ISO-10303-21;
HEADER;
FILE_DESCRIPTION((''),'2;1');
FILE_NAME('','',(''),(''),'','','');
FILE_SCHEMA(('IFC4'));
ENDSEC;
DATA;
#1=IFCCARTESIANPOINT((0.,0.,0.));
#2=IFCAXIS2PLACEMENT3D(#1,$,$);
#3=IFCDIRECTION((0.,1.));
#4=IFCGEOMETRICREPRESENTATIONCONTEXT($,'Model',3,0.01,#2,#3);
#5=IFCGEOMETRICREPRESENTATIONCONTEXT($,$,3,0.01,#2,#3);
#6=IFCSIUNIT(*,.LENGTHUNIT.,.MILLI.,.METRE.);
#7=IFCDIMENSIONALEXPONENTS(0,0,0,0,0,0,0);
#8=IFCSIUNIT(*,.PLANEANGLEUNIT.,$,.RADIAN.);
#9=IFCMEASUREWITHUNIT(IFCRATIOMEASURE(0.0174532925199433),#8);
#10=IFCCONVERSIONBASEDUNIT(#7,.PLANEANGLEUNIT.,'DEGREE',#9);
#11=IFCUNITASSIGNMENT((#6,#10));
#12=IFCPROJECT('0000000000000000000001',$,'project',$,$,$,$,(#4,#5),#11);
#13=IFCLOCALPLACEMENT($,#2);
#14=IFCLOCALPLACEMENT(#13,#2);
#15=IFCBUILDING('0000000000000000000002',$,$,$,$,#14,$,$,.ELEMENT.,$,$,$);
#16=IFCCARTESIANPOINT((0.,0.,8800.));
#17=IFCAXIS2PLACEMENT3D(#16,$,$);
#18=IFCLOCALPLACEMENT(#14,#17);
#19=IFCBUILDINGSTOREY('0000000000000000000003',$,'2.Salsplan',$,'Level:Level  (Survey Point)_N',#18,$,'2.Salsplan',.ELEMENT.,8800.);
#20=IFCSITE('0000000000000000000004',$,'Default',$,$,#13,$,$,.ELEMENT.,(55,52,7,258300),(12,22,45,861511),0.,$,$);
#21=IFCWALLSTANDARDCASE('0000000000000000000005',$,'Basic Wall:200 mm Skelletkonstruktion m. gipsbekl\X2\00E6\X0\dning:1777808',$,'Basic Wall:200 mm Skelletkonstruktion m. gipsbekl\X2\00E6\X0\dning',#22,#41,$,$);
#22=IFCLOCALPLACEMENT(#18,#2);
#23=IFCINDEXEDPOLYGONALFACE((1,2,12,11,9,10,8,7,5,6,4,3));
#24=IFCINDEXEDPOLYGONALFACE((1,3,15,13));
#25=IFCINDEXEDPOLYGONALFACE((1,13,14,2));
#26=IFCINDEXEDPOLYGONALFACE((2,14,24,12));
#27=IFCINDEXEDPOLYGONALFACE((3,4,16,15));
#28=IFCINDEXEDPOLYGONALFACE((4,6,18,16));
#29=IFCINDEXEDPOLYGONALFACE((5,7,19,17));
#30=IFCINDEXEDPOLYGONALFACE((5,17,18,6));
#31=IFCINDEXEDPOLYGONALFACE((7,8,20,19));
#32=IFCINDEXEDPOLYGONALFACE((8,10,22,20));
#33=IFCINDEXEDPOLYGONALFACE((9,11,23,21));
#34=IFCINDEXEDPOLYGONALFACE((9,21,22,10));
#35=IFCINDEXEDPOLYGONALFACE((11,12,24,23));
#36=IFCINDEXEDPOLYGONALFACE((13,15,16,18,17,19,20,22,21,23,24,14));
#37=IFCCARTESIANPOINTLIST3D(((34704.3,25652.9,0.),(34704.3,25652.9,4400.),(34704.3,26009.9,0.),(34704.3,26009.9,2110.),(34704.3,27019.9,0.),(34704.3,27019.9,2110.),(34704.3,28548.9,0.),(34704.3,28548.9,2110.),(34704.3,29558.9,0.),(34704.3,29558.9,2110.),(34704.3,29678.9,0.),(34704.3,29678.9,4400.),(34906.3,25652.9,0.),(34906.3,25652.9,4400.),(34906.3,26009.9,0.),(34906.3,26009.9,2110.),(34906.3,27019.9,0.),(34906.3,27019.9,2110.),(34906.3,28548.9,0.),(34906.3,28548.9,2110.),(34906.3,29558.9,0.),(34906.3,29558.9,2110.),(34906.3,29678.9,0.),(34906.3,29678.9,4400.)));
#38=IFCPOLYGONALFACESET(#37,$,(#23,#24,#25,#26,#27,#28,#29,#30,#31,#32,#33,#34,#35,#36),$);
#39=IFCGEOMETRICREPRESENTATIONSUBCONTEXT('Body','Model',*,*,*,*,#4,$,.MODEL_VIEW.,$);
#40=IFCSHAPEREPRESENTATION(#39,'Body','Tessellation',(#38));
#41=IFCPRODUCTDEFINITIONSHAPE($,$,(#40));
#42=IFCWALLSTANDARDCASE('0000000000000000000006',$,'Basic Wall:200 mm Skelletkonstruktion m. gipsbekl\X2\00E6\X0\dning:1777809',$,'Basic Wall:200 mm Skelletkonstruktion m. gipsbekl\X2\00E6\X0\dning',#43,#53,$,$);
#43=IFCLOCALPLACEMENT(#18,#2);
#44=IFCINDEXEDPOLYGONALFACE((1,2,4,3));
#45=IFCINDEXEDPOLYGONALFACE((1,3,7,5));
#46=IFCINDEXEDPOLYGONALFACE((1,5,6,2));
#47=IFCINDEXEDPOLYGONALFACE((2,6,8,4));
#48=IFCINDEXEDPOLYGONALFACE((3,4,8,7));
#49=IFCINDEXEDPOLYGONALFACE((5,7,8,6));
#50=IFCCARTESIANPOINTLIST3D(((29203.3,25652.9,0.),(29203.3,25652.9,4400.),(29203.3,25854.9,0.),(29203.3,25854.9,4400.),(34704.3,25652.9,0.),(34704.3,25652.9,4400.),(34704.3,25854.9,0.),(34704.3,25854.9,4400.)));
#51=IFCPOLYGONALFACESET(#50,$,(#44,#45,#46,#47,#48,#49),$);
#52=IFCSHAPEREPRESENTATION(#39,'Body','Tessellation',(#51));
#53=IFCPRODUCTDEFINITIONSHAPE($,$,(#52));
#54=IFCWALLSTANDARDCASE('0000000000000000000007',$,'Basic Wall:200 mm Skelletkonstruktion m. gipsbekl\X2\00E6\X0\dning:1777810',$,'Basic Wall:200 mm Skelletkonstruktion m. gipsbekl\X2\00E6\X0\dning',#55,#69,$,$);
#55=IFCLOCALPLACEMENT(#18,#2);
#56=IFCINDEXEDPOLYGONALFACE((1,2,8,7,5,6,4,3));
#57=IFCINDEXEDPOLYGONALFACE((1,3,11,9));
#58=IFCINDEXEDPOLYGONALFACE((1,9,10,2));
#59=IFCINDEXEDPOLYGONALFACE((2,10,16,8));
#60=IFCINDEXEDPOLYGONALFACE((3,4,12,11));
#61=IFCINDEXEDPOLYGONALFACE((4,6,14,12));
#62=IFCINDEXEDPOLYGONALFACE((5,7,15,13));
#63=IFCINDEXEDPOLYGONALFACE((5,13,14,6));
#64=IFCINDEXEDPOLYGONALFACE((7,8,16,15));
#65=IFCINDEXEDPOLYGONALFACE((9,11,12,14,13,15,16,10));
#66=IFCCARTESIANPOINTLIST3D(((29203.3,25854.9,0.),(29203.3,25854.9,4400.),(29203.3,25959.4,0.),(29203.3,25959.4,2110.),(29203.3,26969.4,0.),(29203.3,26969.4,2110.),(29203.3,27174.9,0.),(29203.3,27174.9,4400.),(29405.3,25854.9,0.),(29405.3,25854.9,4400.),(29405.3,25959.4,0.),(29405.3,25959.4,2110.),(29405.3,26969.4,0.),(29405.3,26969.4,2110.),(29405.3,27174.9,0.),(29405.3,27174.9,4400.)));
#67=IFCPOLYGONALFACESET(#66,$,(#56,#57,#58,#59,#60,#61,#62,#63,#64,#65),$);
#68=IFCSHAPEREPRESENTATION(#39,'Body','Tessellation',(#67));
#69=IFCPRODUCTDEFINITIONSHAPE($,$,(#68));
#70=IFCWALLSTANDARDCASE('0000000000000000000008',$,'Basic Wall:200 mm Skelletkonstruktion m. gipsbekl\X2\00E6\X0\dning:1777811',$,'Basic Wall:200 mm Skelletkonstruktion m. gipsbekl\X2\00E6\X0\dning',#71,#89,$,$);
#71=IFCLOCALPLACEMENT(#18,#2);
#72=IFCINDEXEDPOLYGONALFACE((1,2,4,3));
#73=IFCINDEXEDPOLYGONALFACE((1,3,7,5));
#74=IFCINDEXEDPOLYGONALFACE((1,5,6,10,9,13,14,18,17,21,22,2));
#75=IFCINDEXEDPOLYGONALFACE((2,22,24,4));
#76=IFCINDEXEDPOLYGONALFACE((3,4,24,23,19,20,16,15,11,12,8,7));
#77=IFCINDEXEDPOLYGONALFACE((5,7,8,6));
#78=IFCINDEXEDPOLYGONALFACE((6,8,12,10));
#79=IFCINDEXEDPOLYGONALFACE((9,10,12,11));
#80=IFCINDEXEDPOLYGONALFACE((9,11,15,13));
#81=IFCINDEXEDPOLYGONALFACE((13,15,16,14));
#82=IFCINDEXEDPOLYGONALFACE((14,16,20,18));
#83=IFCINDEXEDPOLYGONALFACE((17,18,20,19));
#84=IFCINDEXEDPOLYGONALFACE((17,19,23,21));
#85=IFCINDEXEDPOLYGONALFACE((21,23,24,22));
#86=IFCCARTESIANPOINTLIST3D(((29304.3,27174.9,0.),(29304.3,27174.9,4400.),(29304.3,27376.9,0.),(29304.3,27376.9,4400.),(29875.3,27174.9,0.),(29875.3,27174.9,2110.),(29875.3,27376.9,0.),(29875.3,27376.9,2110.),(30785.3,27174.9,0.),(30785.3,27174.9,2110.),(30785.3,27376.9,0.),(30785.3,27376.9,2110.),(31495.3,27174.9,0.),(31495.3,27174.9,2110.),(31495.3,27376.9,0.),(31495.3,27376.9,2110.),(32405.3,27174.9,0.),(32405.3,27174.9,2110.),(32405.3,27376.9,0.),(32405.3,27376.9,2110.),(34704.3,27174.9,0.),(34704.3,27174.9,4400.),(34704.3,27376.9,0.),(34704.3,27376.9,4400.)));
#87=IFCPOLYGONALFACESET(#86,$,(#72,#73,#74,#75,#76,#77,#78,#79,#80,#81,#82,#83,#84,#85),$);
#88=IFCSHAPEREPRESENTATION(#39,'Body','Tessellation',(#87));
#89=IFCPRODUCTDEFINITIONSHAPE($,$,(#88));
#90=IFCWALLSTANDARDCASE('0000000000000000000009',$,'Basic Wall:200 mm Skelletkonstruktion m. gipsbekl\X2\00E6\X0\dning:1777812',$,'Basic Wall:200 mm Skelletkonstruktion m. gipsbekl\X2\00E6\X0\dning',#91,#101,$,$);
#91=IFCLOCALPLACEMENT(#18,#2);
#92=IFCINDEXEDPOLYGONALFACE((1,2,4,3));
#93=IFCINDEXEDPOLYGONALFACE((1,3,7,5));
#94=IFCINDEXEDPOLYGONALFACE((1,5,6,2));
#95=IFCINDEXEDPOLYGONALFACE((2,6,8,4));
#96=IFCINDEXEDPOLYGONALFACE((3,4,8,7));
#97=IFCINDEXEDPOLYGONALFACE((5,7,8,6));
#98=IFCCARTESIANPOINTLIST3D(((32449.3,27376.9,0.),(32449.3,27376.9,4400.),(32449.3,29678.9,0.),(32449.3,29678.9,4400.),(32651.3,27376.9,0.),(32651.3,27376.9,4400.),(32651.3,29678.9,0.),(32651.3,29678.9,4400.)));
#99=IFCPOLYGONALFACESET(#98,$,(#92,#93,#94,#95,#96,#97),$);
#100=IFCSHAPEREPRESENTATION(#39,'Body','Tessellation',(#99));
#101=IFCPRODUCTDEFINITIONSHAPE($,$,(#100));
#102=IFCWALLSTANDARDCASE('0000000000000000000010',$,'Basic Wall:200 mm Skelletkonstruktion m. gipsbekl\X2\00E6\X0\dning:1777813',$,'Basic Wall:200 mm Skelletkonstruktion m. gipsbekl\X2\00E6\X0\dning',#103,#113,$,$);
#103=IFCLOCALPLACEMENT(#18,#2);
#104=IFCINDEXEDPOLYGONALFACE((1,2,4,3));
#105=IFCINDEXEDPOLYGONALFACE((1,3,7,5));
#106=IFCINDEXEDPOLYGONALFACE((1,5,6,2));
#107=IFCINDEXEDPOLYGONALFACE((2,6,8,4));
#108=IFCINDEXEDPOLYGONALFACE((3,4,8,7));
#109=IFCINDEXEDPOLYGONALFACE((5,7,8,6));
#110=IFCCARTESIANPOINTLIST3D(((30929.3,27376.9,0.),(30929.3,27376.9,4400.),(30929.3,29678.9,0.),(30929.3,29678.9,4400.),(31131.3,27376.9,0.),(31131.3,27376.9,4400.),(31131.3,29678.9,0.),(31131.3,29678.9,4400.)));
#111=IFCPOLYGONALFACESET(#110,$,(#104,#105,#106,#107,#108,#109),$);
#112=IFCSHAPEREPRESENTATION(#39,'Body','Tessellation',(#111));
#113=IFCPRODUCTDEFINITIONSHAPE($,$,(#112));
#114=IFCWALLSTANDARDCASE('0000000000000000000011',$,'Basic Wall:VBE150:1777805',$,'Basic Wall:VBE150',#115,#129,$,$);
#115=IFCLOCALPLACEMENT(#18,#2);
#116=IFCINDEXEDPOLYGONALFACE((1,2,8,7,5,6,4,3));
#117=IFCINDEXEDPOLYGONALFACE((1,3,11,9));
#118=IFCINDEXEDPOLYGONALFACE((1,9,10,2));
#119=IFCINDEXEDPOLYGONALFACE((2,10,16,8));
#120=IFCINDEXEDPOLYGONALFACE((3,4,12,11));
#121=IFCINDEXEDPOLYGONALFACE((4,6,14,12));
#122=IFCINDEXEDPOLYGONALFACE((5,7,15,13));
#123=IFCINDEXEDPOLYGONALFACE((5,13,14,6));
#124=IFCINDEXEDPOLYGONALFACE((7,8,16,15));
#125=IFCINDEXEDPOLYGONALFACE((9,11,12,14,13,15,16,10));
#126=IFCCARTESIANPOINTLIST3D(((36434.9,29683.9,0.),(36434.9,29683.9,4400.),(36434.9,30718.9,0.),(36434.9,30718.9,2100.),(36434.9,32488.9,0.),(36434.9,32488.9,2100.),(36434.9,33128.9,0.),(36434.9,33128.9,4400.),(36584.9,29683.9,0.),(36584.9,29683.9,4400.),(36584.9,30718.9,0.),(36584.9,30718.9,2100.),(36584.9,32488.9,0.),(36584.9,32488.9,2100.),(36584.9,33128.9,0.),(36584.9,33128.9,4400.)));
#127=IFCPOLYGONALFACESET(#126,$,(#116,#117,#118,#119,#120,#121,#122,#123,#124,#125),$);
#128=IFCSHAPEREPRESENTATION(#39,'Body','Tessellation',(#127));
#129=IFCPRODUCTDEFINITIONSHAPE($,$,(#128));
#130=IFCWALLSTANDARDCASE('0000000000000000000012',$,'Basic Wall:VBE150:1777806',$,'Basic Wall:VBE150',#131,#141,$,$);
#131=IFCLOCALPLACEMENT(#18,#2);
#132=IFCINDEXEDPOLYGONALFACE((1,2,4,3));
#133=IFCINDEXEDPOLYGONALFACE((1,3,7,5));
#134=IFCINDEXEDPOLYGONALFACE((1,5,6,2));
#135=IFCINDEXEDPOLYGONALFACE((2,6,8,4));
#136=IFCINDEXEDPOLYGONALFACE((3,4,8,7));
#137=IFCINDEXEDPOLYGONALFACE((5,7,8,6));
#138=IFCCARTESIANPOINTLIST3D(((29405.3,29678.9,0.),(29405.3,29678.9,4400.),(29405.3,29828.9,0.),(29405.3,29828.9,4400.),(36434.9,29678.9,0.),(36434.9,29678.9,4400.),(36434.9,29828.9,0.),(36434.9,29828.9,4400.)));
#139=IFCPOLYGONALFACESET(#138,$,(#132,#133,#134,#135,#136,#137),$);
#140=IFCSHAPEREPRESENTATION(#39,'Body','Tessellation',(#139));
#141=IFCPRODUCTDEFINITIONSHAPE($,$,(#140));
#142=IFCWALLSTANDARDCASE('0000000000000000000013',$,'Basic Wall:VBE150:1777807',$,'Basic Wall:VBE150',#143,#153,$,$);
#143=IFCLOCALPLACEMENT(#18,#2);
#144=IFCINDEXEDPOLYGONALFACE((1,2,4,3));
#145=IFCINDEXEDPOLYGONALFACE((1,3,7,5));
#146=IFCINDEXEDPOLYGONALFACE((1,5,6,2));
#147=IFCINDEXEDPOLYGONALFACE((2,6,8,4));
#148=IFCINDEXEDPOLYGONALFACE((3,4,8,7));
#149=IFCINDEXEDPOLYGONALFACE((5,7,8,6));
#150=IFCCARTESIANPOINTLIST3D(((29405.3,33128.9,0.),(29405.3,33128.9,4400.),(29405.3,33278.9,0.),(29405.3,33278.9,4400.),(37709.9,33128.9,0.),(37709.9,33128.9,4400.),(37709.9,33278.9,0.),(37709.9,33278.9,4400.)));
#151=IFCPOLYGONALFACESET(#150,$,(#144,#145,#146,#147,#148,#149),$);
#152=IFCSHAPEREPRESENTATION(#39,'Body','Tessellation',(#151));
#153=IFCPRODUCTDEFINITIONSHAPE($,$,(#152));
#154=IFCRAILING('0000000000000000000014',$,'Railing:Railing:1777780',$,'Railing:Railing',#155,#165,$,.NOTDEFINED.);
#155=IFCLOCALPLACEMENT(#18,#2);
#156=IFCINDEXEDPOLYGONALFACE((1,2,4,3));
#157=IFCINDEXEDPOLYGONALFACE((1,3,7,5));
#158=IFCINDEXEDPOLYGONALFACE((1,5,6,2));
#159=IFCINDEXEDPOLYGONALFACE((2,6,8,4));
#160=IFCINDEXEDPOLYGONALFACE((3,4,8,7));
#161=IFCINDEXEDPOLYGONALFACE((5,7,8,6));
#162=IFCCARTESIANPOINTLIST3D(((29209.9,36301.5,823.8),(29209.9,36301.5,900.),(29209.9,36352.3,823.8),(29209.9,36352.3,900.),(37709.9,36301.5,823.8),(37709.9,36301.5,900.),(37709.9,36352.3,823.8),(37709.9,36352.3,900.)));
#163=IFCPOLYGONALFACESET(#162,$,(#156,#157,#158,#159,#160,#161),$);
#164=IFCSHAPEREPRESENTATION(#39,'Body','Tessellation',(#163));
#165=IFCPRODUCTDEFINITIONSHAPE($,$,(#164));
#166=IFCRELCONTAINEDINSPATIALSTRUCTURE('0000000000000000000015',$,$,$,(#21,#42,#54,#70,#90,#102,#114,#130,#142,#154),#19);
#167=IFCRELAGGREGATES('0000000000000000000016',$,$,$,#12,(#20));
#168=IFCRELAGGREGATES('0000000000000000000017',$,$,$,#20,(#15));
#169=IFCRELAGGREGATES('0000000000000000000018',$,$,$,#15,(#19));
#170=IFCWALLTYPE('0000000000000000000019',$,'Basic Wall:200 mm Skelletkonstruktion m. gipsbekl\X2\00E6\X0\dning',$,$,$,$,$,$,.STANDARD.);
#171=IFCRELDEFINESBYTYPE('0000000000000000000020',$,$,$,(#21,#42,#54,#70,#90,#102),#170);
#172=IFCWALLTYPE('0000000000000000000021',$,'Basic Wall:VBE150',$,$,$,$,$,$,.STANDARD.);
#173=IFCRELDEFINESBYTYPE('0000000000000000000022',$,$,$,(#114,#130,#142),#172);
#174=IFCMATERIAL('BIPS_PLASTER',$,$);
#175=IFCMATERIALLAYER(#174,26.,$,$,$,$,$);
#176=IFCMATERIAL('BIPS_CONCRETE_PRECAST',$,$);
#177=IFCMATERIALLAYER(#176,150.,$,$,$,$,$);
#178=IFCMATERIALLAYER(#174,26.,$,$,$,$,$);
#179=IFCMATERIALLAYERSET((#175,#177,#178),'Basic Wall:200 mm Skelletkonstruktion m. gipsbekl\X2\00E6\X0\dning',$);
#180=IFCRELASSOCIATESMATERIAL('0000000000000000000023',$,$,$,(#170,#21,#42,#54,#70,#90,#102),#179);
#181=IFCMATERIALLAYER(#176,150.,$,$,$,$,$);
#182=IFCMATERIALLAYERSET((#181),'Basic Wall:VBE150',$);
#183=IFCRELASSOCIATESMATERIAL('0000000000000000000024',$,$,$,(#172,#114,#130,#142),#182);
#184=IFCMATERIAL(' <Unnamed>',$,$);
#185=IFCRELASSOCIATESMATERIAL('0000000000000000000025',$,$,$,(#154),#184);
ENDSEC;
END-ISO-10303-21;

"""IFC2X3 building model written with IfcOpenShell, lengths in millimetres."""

from ifc_helpers import new_model, entity, si_unit, converted_unit, direction, frame, frame_2d, origin, place, context, subcontext, project, spatial, rectangle, extrude, material, layer, layer_set, layer_usage, type_object, element, save


model = new_model("IFC2X3")

# Units and contexts
model_context = context("Model", 3, precision=0.01, world=origin(), true_north=direction((0.0, 1.0)))
context_of_model = context(None, 3, precision=0.01, world=origin(), true_north=direction((0.0, 1.0)))
body_context = subcontext(model_context, "Body", "Model", "MODEL_VIEW")
ifc_project = project(units=[si_unit("LENGTHUNIT", "METRE", prefix="MILLI"), converted_unit("PLANEANGLEUNIT", "DEGREE", entity("IfcRatioMeasure", 0.0174532925199433), si_unit("PLANEANGLEUNIT", "RADIAN"), dimensions=[0, 0, 0, 0, 0, 0, 0])], contexts=[model_context, context_of_model])

# Site, building, storey
site_placement = place(None, origin())
site = spatial("IfcSite", under=ifc_project, at=site_placement, Name="Default", CompositionType="ELEMENT", RefLatitude=(55, 52, 7, 258300), RefLongitude=(12, 22, 45, 861511), RefElevation=0.0)
building_placement = place(site_placement, origin())
building = spatial("IfcBuilding", under=site, at=building_placement, CompositionType="ELEMENT")
storey_placement = place(building_placement, frame((0.0, 0.0, 8800.0)))
storey = spatial("IfcBuildingStorey", under=building, at=storey_placement, Name="2.Salsplan", ObjectType="Level:Level  (Survey Point)_N", LongName="2.Salsplan", CompositionType="ELEMENT", Elevation=8800.0)

# Shared definitions
ifc_material_1 = material(Name="BIPS_CONCRETE_PRECAST")

# Wall, openings
ifc_material_2 = material(Name="BIPS_PLASTER")
ifc_layer_1 = layer(ifc_material_2, 26.0)
ifc_layer_2 = layer(ifc_material_1, 150.0)
ifc_layer_3 = layer(ifc_material_2, 26.0)
ifc_layer_set_1 = layer_set([ifc_layer_1, ifc_layer_2, ifc_layer_3], Name="Basic Wall:200 mm Skelletkonstruktion m. gipsbeklædning")
ifc_layer_usage_1 = layer_usage(ifc_layer_set_1, "AXIS2", "NEGATIVE", 101.0)
wall_type_1 = type_object("IfcWallType", Name="Basic Wall:200 mm Skelletkonstruktion m. gipsbeklædning", PredefinedType="STANDARD", material=ifc_layer_set_1)
wall_1_placement = place(storey_placement, frame((34805.3, 29678.9, 0.0), z_axis=(0.0, 0.0, 1.0), x_axis=(0.0, -1.0, 0.0)))
wall_1 = element("IfcWallStandardCase", 1, at=wall_1_placement, inside=storey, type_object=wall_type_1, material=ifc_layer_usage_1, Name="Basic Wall:200 mm Skelletkonstruktion m. gipsbeklædning:1777808", ObjectType="Basic Wall:200 mm Skelletkonstruktion m. gipsbeklædning", context=body_context, shape_type="SweptSolid", body=[
    extrude(rectangle(XDim=4026.0, YDim=202.0, at=frame_2d((2013.0, 0.0), x_axis=(-1.0, 0.0))), origin(), (0.0, 0.0, 1.0), 4400.0),
])
opening_1_placement = place(wall_1_placement, frame((1130.0, 101.0, 0.0)))
element("IfcOpeningElement", 2, at=opening_1_placement, cuts=wall_1, ObjectType="Opening", context=body_context, shape_type="SweptSolid", body=[
    extrude(rectangle(XDim=2110.0, YDim=1010.0, at=frame_2d((1055.0, 505.0), x_axis=(1.0, 0.0))), frame((0.0, 0.0, 0.0), z_axis=(0.0, -1.0, 0.0), x_axis=(0.0, 0.0, 1.0)), (0.0, 0.0, 1.0), 202.0),
])
opening_2_placement = place(wall_1_placement, frame((3669.0, 101.0, 0.0)))
element("IfcOpeningElement", 3, at=opening_2_placement, cuts=wall_1, ObjectType="Opening", context=body_context, shape_type="SweptSolid", body=[
    extrude(rectangle(XDim=2110.0, YDim=1010.0, at=frame_2d((1055.0, 505.0), x_axis=(1.0, 0.0))), frame((0.0, 0.0, 0.0), z_axis=(0.0, -1.0, 0.0), x_axis=(0.0, 0.0, 1.0)), (0.0, 0.0, 1.0), 202.0),
])

# Wall
ifc_layer_usage_2 = layer_usage(ifc_layer_set_1, "AXIS2", "NEGATIVE", 101.0)
wall_2_placement = place(storey_placement, frame((34704.3, 25753.9, 0.0), z_axis=(0.0, 0.0, 1.0), x_axis=(-1.0, 0.0, 0.0)))
element("IfcWallStandardCase", 4, at=wall_2_placement, inside=storey, type_object=wall_type_1, material=ifc_layer_usage_2, Name="Basic Wall:200 mm Skelletkonstruktion m. gipsbeklædning:1777809", ObjectType="Basic Wall:200 mm Skelletkonstruktion m. gipsbeklædning", context=body_context, shape_type="SweptSolid", body=[
    extrude(rectangle(XDim=5501.0, YDim=202.0, at=frame_2d((2750.5, 0.0), x_axis=(-1.0, 0.0))), origin(), (0.0, 0.0, 1.0), 4400.0),
])

# Wall, opening
ifc_layer_usage_3 = layer_usage(ifc_layer_set_1, "AXIS2", "NEGATIVE", 101.0)
wall_3_placement = place(storey_placement, frame((29304.3, 25854.9, 0.0), z_axis=(0.0, 0.0, 1.0), x_axis=(0.0, 1.0, 0.0)))
wall_3 = element("IfcWallStandardCase", 5, at=wall_3_placement, inside=storey, type_object=wall_type_1, material=ifc_layer_usage_3, Name="Basic Wall:200 mm Skelletkonstruktion m. gipsbeklædning:1777810", ObjectType="Basic Wall:200 mm Skelletkonstruktion m. gipsbeklædning", context=body_context, shape_type="SweptSolid", body=[
    extrude(rectangle(XDim=1320.0, YDim=202.0, at=frame_2d((660.0, 0.0), x_axis=(-1.0, 0.0))), origin(), (0.0, 0.0, 1.0), 4400.0),
])
opening_3_placement = place(wall_3_placement, frame((1114.5, 101.0, 0.0)))
element("IfcOpeningElement", 6, at=opening_3_placement, cuts=wall_3, ObjectType="Opening", context=body_context, shape_type="SweptSolid", body=[
    extrude(rectangle(XDim=2110.0, YDim=1010.0, at=frame_2d((1055.0, 505.0), x_axis=(1.0, 0.0))), frame((0.0, 0.0, 0.0), z_axis=(0.0, -1.0, 0.0), x_axis=(0.0, 0.0, 1.0)), (0.0, 0.0, 1.0), 202.0),
])

# Wall, openings
ifc_layer_usage_4 = layer_usage(ifc_layer_set_1, "AXIS2", "NEGATIVE", 101.0)
wall_4_placement = place(storey_placement, frame((29304.3, 27275.9, 0.0)))
wall_4 = element("IfcWallStandardCase", 7, at=wall_4_placement, inside=storey, type_object=wall_type_1, material=ifc_layer_usage_4, Name="Basic Wall:200 mm Skelletkonstruktion m. gipsbeklædning:1777811", ObjectType="Basic Wall:200 mm Skelletkonstruktion m. gipsbeklædning", context=body_context, shape_type="SweptSolid", body=[
    extrude(rectangle(XDim=5400.0, YDim=202.0, at=frame_2d((2700.0, 0.0), x_axis=(-1.0, 0.0))), origin(), (0.0, 0.0, 1.0), 4400.0),
])
opening_4_placement = place(wall_4_placement, frame((571.0, -101.0, 0.0)))
element("IfcOpeningElement", 8, at=opening_4_placement, cuts=wall_4, ObjectType="Opening", context=body_context, shape_type="SweptSolid", body=[
    extrude(rectangle(XDim=2110.0, YDim=910.0, at=frame_2d((1055.0, 455.0), x_axis=(1.0, 0.0))), frame((0.0, 0.0, 0.0), z_axis=(0.0, 1.0, 0.0), x_axis=(0.0, 0.0, 1.0)), (0.0, 0.0, 1.0), 202.0),
])
opening_5_placement = place(wall_4_placement, frame((2191.0, -101.0, 0.0)))
element("IfcOpeningElement", 9, at=opening_5_placement, cuts=wall_4, ObjectType="Opening", context=body_context, shape_type="SweptSolid", body=[
    extrude(rectangle(XDim=2110.0, YDim=910.0, at=frame_2d((1055.0, 455.0), x_axis=(1.0, 0.0))), frame((0.0, 0.0, 0.0), z_axis=(0.0, 1.0, 0.0), x_axis=(0.0, 0.0, 1.0)), (0.0, 0.0, 1.0), 202.0),
])

# Walls
ifc_layer_usage_5 = layer_usage(ifc_layer_set_1, "AXIS2", "NEGATIVE", 101.0)
wall_5_placement = place(storey_placement, frame((32550.3, 27376.9, 0.0), z_axis=(0.0, 0.0, 1.0), x_axis=(0.0, 1.0, 0.0)))
element("IfcWallStandardCase", 10, at=wall_5_placement, inside=storey, type_object=wall_type_1, material=ifc_layer_usage_5, Name="Basic Wall:200 mm Skelletkonstruktion m. gipsbeklædning:1777812", ObjectType="Basic Wall:200 mm Skelletkonstruktion m. gipsbeklædning", context=body_context, shape_type="SweptSolid", body=[
    extrude(rectangle(XDim=2302.0, YDim=202.0, at=frame_2d((1151.0, 0.0), x_axis=(-1.0, 0.0))), origin(), (0.0, 0.0, 1.0), 4400.0),
])
ifc_layer_usage_6 = layer_usage(ifc_layer_set_1, "AXIS2", "NEGATIVE", 101.0)
wall_6_placement = place(storey_placement, frame((31030.3, 27376.9, 0.0), z_axis=(0.0, 0.0, 1.0), x_axis=(0.0, 1.0, 0.0)))
element("IfcWallStandardCase", 11, at=wall_6_placement, inside=storey, type_object=wall_type_1, material=ifc_layer_usage_6, Name="Basic Wall:200 mm Skelletkonstruktion m. gipsbeklædning:1777813", ObjectType="Basic Wall:200 mm Skelletkonstruktion m. gipsbeklædning", context=body_context, shape_type="SweptSolid", body=[
    extrude(rectangle(XDim=2302.0, YDim=202.0, at=frame_2d((1151.0, 0.0), x_axis=(-1.0, 0.0))), origin(), (0.0, 0.0, 1.0), 4400.0),
])

# Wall, opening
ifc_layer_4 = layer(ifc_material_1, 150.0)
ifc_layer_set_2 = layer_set([ifc_layer_4], Name="Basic Wall:VBE150")
ifc_layer_usage_7 = layer_usage(ifc_layer_set_2, "AXIS2", "NEGATIVE", 75.0)
wall_type_2 = type_object("IfcWallType", Name="Basic Wall:VBE150", PredefinedType="STANDARD", material=ifc_layer_set_2)
wall_7_placement = place(storey_placement, frame((36509.9, 29683.9, 0.0), z_axis=(0.0, 0.0, 1.0), x_axis=(0.0, 1.0, 0.0)))
wall_7 = element("IfcWallStandardCase", 12, at=wall_7_placement, inside=storey, type_object=wall_type_2, material=ifc_layer_usage_7, Name="Basic Wall:VBE150:1777805", ObjectType="Basic Wall:VBE150", context=body_context, shape_type="SweptSolid", body=[
    extrude(rectangle(XDim=3445.0, YDim=150.0, at=frame_2d((1722.5, 0.0), x_axis=(-1.0, 0.0))), origin(), (0.0, 0.0, 1.0), 4400.0),
])
opening_6_placement = place(wall_7_placement, frame((1035.0, -75.0, 0.0)))
element("IfcOpeningElement", 13, at=opening_6_placement, cuts=wall_7, ObjectType="Opening", context=body_context, shape_type="SweptSolid", body=[
    extrude(rectangle(XDim=2100.0, YDim=1770.0, at=frame_2d((1050.0, 885.0), x_axis=(1.0, 0.0))), frame((0.0, 0.0, 0.0), z_axis=(0.0, 1.0, 0.0), x_axis=(0.0, 0.0, 1.0)), (0.0, 0.0, 1.0), 150.0),
])

# Walls
ifc_layer_usage_8 = layer_usage(ifc_layer_set_2, "AXIS2", "NEGATIVE", 75.0)
wall_8_placement = place(storey_placement, frame((29405.3, 29753.9, 0.0)))
element("IfcWallStandardCase", 14, at=wall_8_placement, inside=storey, type_object=wall_type_2, material=ifc_layer_usage_8, Name="Basic Wall:VBE150:1777806", ObjectType="Basic Wall:VBE150", context=body_context, shape_type="SweptSolid", body=[
    extrude(rectangle(XDim=7029.6, YDim=150.0, at=frame_2d((3514.8, 0.0), x_axis=(-1.0, 0.0))), origin(), (0.0, 0.0, 1.0), 4400.0),
])
ifc_layer_usage_9 = layer_usage(ifc_layer_set_2, "AXIS2", "NEGATIVE", 75.0)
wall_9_placement = place(storey_placement, frame((29405.3, 33203.9, 0.0)))
element("IfcWallStandardCase", 15, at=wall_9_placement, inside=storey, type_object=wall_type_2, material=ifc_layer_usage_9, Name="Basic Wall:VBE150:1777807", ObjectType="Basic Wall:VBE150", context=body_context, shape_type="SweptSolid", body=[
    extrude(rectangle(XDim=8304.6, YDim=150.0, at=frame_2d((4152.3, 0.0), x_axis=(-1.0, 0.0))), origin(), (0.0, 0.0, 1.0), 4400.0),
])

# Railing
ifc_material_3 = material(Name=" <Unnamed>")
railing_placement = place(storey_placement, origin())
element("IfcRailing", 16, at=railing_placement, inside=storey, material=ifc_material_3, Name="Railing:Railing:1777780", ObjectType="Railing:Railing", PredefinedType="NOTDEFINED", context=body_context, shape_type="SweptSolid", body=[
    extrude(rectangle(XDim=8500.0, YDim=50.8, at=frame_2d((0.0, 0.0), x_axis=(1.0, 0.0))), frame((33459.9, 36326.9, 823.8), z_axis=(0.0, 0.0, 1.0), x_axis=(-1.0, 0.0, 0.0)), (0.0, 0.0, 1.0), 76.2),
])

save(model, "model.ifc")
